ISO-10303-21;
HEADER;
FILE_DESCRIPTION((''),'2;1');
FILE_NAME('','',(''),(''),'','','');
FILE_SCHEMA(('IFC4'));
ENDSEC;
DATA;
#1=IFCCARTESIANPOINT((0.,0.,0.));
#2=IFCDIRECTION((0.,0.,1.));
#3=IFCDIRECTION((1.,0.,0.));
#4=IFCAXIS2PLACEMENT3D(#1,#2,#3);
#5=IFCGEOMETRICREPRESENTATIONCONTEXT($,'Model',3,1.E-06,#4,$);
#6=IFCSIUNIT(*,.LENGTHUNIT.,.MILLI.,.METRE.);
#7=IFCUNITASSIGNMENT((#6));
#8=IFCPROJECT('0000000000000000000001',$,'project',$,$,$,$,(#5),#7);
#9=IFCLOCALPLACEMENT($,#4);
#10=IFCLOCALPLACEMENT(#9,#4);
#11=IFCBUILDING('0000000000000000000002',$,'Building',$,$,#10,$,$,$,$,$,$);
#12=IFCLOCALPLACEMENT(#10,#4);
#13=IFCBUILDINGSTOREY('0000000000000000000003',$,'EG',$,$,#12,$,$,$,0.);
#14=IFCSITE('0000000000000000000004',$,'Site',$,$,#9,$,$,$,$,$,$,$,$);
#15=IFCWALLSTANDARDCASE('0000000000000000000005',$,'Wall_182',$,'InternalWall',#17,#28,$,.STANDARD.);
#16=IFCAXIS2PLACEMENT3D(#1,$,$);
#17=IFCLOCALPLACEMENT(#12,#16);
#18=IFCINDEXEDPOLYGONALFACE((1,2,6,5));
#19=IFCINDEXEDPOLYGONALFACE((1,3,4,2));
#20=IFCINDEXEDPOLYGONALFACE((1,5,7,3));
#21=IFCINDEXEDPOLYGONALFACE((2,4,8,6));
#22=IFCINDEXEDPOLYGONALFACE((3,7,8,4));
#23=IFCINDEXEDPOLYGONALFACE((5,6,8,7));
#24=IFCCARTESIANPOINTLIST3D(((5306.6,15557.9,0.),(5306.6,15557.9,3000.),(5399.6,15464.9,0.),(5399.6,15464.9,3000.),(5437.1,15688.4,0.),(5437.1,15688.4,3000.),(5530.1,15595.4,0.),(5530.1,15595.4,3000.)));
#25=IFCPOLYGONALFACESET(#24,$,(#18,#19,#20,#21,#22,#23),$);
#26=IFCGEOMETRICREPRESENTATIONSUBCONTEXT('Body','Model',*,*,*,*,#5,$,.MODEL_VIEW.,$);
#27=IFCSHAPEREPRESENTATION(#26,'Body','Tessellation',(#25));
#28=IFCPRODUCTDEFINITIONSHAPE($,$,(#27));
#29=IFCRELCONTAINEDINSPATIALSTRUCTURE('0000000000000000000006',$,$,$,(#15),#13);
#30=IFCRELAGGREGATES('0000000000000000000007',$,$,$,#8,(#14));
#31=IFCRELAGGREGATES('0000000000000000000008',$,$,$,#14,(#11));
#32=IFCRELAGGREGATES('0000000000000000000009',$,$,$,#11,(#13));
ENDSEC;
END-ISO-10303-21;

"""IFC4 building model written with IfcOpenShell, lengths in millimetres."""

from ifc_helpers import new_model, si_unit, frame, origin_with_axes, place, context, subcontext, project, spatial, rectangle, extrude, element, save


model = new_model("IFC4")

# Units and contexts
model_context = context("Model", 3, precision=1e-06, world=origin_with_axes())
body_context = subcontext(model_context, "Body", "Model", "MODEL_VIEW")
ifc_project = project(units=[si_unit("LENGTHUNIT", "METRE", prefix="MILLI")], contexts=[model_context])

# Site, building, storey
site_placement = place(None, origin_with_axes())
site = spatial("IfcSite", under=ifc_project, at=site_placement, Name="Site")
building_placement = place(site_placement, origin_with_axes())
building = spatial("IfcBuilding", under=site, at=building_placement, Name="Building")
storey_placement = place(building_placement, origin_with_axes())
storey = spatial("IfcBuildingStorey", under=building, at=storey_placement, Name="EG", Elevation=0.0)

# Wall
wall_1_placement = place(storey_placement, origin_with_axes())
element("IfcWallStandardCase", 1, at=wall_1_placement, inside=storey, Name="Wall_182", ObjectType="InternalWall", PredefinedType="STANDARD", context=body_context, shape_type="SweptSolid", body=[
    extrude(rectangle(XDim=184.6, YDim=131.5), frame((5418.4, 15576.7, 0.0), z_axis=(0.0, 0.0, 1.0), x_axis=(0.707107, 0.707107, 0.0)), (0.0, 0.0, 1.0), 3000.0),
])

save(model, "model.ifc")
